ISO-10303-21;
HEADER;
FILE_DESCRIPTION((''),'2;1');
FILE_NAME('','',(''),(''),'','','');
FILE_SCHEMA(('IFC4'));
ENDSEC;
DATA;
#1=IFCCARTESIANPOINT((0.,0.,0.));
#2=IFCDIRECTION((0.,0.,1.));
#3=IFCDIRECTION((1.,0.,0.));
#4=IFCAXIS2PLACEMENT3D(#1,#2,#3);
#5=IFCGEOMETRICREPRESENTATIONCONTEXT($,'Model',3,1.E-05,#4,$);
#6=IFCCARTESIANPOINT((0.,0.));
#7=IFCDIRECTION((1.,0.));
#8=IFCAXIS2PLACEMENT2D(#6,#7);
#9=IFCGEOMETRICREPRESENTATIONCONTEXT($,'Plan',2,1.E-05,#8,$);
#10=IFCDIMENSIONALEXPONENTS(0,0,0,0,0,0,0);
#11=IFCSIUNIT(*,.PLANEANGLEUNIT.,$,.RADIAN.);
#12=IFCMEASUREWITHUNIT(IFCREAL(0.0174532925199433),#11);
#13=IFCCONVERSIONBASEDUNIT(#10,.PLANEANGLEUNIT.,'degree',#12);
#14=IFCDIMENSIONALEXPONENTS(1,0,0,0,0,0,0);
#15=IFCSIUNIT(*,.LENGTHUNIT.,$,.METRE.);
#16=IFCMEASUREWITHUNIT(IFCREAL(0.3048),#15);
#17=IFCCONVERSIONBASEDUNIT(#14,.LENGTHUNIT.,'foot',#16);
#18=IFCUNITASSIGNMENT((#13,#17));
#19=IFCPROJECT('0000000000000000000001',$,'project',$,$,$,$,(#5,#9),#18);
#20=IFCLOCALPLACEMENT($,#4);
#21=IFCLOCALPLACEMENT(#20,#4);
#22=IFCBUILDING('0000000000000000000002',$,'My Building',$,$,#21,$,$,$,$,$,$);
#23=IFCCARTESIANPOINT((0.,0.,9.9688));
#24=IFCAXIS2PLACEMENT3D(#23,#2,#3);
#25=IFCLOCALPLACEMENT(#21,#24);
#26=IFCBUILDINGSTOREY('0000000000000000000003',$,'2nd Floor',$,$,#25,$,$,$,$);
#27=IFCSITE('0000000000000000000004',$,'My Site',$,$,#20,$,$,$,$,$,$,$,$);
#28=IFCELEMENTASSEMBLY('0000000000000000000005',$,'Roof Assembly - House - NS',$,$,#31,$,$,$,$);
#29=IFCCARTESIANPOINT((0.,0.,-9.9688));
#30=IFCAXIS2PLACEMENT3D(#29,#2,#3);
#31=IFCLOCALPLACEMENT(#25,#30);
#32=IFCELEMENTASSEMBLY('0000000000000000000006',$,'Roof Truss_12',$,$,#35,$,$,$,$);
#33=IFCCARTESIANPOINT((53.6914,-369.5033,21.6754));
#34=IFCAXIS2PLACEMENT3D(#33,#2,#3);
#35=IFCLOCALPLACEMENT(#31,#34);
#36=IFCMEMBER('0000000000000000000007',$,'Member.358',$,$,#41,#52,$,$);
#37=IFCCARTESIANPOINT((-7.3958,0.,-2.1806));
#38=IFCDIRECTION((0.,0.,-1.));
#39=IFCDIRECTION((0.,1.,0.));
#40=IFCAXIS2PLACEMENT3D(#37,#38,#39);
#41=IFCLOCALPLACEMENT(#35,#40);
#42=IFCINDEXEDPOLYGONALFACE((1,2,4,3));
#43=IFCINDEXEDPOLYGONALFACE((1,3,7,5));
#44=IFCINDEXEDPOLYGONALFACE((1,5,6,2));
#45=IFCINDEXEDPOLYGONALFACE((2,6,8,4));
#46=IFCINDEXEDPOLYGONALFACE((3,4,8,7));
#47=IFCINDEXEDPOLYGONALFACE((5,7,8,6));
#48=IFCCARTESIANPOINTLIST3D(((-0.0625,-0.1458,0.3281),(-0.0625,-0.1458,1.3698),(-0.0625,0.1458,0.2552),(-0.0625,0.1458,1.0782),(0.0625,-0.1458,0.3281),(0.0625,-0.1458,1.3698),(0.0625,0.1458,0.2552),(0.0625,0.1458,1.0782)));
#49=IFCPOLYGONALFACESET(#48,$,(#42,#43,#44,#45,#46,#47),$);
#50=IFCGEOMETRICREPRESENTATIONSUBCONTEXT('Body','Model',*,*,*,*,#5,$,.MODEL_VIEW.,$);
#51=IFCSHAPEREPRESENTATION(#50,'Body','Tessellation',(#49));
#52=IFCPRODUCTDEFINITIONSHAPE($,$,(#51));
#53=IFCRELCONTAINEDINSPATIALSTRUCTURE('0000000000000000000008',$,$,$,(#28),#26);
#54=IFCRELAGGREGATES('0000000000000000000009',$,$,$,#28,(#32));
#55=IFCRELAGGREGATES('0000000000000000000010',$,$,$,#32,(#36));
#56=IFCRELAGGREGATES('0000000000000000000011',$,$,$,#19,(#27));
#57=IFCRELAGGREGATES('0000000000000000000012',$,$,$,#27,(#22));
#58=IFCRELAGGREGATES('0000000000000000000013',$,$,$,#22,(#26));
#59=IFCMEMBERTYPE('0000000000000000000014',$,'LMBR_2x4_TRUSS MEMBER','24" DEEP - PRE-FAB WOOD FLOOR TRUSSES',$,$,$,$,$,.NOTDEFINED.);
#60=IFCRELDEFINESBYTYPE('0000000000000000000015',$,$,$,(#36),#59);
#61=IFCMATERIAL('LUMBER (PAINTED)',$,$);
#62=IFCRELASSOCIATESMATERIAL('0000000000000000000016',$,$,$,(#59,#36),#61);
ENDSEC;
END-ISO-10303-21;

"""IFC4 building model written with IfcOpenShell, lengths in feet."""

from ifc_helpers import new_model, entity, si_unit, converted_unit, frame, origin_with_axes, origin_2d_with_axis, place, context, subcontext, project, spatial, indexed_curve, outline, extrude, clip, halfspace, material, material_profile, profile_set, profile_usage, type_object, element, aggregate, save


model = new_model("IFC4")

# Units and contexts
model_context = context("Model", 3, precision=1e-05, world=origin_with_axes())
plan_context = context("Plan", 2, precision=1e-05, world=origin_2d_with_axis())
body_context = subcontext(model_context, "Body", "Model", "MODEL_VIEW")
ifc_project = project(units=[converted_unit("PLANEANGLEUNIT", "degree", entity("IfcReal", 0.0174532925199433), si_unit("PLANEANGLEUNIT", "RADIAN"), dimensions=[0, 0, 0, 0, 0, 0, 0]), converted_unit("LENGTHUNIT", "foot", entity("IfcReal", 0.3048), si_unit("LENGTHUNIT", "METRE"), dimensions=[1, 0, 0, 0, 0, 0, 0])], contexts=[model_context, plan_context])

# Site, building, storey
site_placement = place(None, origin_with_axes())
site = spatial("IfcSite", under=ifc_project, at=site_placement, Name="My Site")
building_placement = place(site_placement, origin_with_axes())
building = spatial("IfcBuilding", under=site, at=building_placement, Name="My Building")
storey_placement = place(building_placement, frame((0.0, 0.0, 9.9688), z_axis=(0.0, 0.0, 1.0), x_axis=(1.0, 0.0, 0.0)))
storey = spatial("IfcBuildingStorey", under=building, at=storey_placement, Name="2nd Floor")

# Element assemblies, member
assembly_1_placement = place(storey_placement, frame((0.0, 0.0, -9.9688), z_axis=(0.0, 0.0, 1.0), x_axis=(1.0, 0.0, 0.0)))
assembly_1 = element("IfcElementAssembly", 1, at=assembly_1_placement, inside=storey, Name="Roof Assembly - House - NS")
ifc_material = material(Name="LUMBER (PAINTED)")
ifc_material_profile_1 = material_profile(ifc_material, outline(indexed_curve([(-0.0625, -0.1458), (0.0625, -0.1458), (0.0625, 0.1458), (-0.0625, 0.1458), (-0.0625, -0.1458)])))
ifc_profile_set_1 = profile_set([ifc_material_profile_1])
member_type_1 = type_object("IfcMemberType", Name="LMBR_2x4_TRUSS MEMBER", Description="24\" DEEP - PRE-FAB WOOD FLOOR TRUSSES", PredefinedType="NOTDEFINED", material=ifc_profile_set_1)
assembly_2_placement = place(assembly_1_placement, frame((53.6914, -369.5033, 21.6754), z_axis=(0.0, 0.0, 1.0), x_axis=(1.0, 0.0, 0.0)))
assembly_2 = element("IfcElementAssembly", 2, at=assembly_2_placement, Name="Roof Truss_12")
ifc_profile_usage_1 = profile_usage(ifc_profile_set_1)
member_1_placement = place(assembly_2_placement, frame((-7.3958, 0.0, -2.1806), z_axis=(0.0, 0.0, -1.0), x_axis=(0.0, 1.0, 0.0)))
member_1 = element("IfcMember", 3, at=member_1_placement, type_object=member_type_1, material=ifc_profile_usage_1, Name="Member.358", context=body_context, shape_type="Clipping", body=[
    clip(clip(extrude(outline(indexed_curve([(-0.0625, -0.1458), (0.0625, -0.1458), (0.0625, 0.1458), (-0.0625, 0.1458), (-0.0625, -0.1458)])), origin_with_axes(), (0.0, 0.0, 1.0), 1.3698), halfspace(frame((0.0, 7.5424, -1.5944), z_axis=(0.0, -0.242599, -0.970127), x_axis=(-1.0, 0.000001, 0.0)), False)), halfspace(frame((397.5032, -0.1458, 1.3698), z_axis=(0.0, 0.707107, 0.707107), x_axis=(1.0, 0.0, 0.0)), False)),
])
aggregate(assembly_1, [assembly_2])
aggregate(assembly_2, [member_1])

save(model, "model.ifc")
